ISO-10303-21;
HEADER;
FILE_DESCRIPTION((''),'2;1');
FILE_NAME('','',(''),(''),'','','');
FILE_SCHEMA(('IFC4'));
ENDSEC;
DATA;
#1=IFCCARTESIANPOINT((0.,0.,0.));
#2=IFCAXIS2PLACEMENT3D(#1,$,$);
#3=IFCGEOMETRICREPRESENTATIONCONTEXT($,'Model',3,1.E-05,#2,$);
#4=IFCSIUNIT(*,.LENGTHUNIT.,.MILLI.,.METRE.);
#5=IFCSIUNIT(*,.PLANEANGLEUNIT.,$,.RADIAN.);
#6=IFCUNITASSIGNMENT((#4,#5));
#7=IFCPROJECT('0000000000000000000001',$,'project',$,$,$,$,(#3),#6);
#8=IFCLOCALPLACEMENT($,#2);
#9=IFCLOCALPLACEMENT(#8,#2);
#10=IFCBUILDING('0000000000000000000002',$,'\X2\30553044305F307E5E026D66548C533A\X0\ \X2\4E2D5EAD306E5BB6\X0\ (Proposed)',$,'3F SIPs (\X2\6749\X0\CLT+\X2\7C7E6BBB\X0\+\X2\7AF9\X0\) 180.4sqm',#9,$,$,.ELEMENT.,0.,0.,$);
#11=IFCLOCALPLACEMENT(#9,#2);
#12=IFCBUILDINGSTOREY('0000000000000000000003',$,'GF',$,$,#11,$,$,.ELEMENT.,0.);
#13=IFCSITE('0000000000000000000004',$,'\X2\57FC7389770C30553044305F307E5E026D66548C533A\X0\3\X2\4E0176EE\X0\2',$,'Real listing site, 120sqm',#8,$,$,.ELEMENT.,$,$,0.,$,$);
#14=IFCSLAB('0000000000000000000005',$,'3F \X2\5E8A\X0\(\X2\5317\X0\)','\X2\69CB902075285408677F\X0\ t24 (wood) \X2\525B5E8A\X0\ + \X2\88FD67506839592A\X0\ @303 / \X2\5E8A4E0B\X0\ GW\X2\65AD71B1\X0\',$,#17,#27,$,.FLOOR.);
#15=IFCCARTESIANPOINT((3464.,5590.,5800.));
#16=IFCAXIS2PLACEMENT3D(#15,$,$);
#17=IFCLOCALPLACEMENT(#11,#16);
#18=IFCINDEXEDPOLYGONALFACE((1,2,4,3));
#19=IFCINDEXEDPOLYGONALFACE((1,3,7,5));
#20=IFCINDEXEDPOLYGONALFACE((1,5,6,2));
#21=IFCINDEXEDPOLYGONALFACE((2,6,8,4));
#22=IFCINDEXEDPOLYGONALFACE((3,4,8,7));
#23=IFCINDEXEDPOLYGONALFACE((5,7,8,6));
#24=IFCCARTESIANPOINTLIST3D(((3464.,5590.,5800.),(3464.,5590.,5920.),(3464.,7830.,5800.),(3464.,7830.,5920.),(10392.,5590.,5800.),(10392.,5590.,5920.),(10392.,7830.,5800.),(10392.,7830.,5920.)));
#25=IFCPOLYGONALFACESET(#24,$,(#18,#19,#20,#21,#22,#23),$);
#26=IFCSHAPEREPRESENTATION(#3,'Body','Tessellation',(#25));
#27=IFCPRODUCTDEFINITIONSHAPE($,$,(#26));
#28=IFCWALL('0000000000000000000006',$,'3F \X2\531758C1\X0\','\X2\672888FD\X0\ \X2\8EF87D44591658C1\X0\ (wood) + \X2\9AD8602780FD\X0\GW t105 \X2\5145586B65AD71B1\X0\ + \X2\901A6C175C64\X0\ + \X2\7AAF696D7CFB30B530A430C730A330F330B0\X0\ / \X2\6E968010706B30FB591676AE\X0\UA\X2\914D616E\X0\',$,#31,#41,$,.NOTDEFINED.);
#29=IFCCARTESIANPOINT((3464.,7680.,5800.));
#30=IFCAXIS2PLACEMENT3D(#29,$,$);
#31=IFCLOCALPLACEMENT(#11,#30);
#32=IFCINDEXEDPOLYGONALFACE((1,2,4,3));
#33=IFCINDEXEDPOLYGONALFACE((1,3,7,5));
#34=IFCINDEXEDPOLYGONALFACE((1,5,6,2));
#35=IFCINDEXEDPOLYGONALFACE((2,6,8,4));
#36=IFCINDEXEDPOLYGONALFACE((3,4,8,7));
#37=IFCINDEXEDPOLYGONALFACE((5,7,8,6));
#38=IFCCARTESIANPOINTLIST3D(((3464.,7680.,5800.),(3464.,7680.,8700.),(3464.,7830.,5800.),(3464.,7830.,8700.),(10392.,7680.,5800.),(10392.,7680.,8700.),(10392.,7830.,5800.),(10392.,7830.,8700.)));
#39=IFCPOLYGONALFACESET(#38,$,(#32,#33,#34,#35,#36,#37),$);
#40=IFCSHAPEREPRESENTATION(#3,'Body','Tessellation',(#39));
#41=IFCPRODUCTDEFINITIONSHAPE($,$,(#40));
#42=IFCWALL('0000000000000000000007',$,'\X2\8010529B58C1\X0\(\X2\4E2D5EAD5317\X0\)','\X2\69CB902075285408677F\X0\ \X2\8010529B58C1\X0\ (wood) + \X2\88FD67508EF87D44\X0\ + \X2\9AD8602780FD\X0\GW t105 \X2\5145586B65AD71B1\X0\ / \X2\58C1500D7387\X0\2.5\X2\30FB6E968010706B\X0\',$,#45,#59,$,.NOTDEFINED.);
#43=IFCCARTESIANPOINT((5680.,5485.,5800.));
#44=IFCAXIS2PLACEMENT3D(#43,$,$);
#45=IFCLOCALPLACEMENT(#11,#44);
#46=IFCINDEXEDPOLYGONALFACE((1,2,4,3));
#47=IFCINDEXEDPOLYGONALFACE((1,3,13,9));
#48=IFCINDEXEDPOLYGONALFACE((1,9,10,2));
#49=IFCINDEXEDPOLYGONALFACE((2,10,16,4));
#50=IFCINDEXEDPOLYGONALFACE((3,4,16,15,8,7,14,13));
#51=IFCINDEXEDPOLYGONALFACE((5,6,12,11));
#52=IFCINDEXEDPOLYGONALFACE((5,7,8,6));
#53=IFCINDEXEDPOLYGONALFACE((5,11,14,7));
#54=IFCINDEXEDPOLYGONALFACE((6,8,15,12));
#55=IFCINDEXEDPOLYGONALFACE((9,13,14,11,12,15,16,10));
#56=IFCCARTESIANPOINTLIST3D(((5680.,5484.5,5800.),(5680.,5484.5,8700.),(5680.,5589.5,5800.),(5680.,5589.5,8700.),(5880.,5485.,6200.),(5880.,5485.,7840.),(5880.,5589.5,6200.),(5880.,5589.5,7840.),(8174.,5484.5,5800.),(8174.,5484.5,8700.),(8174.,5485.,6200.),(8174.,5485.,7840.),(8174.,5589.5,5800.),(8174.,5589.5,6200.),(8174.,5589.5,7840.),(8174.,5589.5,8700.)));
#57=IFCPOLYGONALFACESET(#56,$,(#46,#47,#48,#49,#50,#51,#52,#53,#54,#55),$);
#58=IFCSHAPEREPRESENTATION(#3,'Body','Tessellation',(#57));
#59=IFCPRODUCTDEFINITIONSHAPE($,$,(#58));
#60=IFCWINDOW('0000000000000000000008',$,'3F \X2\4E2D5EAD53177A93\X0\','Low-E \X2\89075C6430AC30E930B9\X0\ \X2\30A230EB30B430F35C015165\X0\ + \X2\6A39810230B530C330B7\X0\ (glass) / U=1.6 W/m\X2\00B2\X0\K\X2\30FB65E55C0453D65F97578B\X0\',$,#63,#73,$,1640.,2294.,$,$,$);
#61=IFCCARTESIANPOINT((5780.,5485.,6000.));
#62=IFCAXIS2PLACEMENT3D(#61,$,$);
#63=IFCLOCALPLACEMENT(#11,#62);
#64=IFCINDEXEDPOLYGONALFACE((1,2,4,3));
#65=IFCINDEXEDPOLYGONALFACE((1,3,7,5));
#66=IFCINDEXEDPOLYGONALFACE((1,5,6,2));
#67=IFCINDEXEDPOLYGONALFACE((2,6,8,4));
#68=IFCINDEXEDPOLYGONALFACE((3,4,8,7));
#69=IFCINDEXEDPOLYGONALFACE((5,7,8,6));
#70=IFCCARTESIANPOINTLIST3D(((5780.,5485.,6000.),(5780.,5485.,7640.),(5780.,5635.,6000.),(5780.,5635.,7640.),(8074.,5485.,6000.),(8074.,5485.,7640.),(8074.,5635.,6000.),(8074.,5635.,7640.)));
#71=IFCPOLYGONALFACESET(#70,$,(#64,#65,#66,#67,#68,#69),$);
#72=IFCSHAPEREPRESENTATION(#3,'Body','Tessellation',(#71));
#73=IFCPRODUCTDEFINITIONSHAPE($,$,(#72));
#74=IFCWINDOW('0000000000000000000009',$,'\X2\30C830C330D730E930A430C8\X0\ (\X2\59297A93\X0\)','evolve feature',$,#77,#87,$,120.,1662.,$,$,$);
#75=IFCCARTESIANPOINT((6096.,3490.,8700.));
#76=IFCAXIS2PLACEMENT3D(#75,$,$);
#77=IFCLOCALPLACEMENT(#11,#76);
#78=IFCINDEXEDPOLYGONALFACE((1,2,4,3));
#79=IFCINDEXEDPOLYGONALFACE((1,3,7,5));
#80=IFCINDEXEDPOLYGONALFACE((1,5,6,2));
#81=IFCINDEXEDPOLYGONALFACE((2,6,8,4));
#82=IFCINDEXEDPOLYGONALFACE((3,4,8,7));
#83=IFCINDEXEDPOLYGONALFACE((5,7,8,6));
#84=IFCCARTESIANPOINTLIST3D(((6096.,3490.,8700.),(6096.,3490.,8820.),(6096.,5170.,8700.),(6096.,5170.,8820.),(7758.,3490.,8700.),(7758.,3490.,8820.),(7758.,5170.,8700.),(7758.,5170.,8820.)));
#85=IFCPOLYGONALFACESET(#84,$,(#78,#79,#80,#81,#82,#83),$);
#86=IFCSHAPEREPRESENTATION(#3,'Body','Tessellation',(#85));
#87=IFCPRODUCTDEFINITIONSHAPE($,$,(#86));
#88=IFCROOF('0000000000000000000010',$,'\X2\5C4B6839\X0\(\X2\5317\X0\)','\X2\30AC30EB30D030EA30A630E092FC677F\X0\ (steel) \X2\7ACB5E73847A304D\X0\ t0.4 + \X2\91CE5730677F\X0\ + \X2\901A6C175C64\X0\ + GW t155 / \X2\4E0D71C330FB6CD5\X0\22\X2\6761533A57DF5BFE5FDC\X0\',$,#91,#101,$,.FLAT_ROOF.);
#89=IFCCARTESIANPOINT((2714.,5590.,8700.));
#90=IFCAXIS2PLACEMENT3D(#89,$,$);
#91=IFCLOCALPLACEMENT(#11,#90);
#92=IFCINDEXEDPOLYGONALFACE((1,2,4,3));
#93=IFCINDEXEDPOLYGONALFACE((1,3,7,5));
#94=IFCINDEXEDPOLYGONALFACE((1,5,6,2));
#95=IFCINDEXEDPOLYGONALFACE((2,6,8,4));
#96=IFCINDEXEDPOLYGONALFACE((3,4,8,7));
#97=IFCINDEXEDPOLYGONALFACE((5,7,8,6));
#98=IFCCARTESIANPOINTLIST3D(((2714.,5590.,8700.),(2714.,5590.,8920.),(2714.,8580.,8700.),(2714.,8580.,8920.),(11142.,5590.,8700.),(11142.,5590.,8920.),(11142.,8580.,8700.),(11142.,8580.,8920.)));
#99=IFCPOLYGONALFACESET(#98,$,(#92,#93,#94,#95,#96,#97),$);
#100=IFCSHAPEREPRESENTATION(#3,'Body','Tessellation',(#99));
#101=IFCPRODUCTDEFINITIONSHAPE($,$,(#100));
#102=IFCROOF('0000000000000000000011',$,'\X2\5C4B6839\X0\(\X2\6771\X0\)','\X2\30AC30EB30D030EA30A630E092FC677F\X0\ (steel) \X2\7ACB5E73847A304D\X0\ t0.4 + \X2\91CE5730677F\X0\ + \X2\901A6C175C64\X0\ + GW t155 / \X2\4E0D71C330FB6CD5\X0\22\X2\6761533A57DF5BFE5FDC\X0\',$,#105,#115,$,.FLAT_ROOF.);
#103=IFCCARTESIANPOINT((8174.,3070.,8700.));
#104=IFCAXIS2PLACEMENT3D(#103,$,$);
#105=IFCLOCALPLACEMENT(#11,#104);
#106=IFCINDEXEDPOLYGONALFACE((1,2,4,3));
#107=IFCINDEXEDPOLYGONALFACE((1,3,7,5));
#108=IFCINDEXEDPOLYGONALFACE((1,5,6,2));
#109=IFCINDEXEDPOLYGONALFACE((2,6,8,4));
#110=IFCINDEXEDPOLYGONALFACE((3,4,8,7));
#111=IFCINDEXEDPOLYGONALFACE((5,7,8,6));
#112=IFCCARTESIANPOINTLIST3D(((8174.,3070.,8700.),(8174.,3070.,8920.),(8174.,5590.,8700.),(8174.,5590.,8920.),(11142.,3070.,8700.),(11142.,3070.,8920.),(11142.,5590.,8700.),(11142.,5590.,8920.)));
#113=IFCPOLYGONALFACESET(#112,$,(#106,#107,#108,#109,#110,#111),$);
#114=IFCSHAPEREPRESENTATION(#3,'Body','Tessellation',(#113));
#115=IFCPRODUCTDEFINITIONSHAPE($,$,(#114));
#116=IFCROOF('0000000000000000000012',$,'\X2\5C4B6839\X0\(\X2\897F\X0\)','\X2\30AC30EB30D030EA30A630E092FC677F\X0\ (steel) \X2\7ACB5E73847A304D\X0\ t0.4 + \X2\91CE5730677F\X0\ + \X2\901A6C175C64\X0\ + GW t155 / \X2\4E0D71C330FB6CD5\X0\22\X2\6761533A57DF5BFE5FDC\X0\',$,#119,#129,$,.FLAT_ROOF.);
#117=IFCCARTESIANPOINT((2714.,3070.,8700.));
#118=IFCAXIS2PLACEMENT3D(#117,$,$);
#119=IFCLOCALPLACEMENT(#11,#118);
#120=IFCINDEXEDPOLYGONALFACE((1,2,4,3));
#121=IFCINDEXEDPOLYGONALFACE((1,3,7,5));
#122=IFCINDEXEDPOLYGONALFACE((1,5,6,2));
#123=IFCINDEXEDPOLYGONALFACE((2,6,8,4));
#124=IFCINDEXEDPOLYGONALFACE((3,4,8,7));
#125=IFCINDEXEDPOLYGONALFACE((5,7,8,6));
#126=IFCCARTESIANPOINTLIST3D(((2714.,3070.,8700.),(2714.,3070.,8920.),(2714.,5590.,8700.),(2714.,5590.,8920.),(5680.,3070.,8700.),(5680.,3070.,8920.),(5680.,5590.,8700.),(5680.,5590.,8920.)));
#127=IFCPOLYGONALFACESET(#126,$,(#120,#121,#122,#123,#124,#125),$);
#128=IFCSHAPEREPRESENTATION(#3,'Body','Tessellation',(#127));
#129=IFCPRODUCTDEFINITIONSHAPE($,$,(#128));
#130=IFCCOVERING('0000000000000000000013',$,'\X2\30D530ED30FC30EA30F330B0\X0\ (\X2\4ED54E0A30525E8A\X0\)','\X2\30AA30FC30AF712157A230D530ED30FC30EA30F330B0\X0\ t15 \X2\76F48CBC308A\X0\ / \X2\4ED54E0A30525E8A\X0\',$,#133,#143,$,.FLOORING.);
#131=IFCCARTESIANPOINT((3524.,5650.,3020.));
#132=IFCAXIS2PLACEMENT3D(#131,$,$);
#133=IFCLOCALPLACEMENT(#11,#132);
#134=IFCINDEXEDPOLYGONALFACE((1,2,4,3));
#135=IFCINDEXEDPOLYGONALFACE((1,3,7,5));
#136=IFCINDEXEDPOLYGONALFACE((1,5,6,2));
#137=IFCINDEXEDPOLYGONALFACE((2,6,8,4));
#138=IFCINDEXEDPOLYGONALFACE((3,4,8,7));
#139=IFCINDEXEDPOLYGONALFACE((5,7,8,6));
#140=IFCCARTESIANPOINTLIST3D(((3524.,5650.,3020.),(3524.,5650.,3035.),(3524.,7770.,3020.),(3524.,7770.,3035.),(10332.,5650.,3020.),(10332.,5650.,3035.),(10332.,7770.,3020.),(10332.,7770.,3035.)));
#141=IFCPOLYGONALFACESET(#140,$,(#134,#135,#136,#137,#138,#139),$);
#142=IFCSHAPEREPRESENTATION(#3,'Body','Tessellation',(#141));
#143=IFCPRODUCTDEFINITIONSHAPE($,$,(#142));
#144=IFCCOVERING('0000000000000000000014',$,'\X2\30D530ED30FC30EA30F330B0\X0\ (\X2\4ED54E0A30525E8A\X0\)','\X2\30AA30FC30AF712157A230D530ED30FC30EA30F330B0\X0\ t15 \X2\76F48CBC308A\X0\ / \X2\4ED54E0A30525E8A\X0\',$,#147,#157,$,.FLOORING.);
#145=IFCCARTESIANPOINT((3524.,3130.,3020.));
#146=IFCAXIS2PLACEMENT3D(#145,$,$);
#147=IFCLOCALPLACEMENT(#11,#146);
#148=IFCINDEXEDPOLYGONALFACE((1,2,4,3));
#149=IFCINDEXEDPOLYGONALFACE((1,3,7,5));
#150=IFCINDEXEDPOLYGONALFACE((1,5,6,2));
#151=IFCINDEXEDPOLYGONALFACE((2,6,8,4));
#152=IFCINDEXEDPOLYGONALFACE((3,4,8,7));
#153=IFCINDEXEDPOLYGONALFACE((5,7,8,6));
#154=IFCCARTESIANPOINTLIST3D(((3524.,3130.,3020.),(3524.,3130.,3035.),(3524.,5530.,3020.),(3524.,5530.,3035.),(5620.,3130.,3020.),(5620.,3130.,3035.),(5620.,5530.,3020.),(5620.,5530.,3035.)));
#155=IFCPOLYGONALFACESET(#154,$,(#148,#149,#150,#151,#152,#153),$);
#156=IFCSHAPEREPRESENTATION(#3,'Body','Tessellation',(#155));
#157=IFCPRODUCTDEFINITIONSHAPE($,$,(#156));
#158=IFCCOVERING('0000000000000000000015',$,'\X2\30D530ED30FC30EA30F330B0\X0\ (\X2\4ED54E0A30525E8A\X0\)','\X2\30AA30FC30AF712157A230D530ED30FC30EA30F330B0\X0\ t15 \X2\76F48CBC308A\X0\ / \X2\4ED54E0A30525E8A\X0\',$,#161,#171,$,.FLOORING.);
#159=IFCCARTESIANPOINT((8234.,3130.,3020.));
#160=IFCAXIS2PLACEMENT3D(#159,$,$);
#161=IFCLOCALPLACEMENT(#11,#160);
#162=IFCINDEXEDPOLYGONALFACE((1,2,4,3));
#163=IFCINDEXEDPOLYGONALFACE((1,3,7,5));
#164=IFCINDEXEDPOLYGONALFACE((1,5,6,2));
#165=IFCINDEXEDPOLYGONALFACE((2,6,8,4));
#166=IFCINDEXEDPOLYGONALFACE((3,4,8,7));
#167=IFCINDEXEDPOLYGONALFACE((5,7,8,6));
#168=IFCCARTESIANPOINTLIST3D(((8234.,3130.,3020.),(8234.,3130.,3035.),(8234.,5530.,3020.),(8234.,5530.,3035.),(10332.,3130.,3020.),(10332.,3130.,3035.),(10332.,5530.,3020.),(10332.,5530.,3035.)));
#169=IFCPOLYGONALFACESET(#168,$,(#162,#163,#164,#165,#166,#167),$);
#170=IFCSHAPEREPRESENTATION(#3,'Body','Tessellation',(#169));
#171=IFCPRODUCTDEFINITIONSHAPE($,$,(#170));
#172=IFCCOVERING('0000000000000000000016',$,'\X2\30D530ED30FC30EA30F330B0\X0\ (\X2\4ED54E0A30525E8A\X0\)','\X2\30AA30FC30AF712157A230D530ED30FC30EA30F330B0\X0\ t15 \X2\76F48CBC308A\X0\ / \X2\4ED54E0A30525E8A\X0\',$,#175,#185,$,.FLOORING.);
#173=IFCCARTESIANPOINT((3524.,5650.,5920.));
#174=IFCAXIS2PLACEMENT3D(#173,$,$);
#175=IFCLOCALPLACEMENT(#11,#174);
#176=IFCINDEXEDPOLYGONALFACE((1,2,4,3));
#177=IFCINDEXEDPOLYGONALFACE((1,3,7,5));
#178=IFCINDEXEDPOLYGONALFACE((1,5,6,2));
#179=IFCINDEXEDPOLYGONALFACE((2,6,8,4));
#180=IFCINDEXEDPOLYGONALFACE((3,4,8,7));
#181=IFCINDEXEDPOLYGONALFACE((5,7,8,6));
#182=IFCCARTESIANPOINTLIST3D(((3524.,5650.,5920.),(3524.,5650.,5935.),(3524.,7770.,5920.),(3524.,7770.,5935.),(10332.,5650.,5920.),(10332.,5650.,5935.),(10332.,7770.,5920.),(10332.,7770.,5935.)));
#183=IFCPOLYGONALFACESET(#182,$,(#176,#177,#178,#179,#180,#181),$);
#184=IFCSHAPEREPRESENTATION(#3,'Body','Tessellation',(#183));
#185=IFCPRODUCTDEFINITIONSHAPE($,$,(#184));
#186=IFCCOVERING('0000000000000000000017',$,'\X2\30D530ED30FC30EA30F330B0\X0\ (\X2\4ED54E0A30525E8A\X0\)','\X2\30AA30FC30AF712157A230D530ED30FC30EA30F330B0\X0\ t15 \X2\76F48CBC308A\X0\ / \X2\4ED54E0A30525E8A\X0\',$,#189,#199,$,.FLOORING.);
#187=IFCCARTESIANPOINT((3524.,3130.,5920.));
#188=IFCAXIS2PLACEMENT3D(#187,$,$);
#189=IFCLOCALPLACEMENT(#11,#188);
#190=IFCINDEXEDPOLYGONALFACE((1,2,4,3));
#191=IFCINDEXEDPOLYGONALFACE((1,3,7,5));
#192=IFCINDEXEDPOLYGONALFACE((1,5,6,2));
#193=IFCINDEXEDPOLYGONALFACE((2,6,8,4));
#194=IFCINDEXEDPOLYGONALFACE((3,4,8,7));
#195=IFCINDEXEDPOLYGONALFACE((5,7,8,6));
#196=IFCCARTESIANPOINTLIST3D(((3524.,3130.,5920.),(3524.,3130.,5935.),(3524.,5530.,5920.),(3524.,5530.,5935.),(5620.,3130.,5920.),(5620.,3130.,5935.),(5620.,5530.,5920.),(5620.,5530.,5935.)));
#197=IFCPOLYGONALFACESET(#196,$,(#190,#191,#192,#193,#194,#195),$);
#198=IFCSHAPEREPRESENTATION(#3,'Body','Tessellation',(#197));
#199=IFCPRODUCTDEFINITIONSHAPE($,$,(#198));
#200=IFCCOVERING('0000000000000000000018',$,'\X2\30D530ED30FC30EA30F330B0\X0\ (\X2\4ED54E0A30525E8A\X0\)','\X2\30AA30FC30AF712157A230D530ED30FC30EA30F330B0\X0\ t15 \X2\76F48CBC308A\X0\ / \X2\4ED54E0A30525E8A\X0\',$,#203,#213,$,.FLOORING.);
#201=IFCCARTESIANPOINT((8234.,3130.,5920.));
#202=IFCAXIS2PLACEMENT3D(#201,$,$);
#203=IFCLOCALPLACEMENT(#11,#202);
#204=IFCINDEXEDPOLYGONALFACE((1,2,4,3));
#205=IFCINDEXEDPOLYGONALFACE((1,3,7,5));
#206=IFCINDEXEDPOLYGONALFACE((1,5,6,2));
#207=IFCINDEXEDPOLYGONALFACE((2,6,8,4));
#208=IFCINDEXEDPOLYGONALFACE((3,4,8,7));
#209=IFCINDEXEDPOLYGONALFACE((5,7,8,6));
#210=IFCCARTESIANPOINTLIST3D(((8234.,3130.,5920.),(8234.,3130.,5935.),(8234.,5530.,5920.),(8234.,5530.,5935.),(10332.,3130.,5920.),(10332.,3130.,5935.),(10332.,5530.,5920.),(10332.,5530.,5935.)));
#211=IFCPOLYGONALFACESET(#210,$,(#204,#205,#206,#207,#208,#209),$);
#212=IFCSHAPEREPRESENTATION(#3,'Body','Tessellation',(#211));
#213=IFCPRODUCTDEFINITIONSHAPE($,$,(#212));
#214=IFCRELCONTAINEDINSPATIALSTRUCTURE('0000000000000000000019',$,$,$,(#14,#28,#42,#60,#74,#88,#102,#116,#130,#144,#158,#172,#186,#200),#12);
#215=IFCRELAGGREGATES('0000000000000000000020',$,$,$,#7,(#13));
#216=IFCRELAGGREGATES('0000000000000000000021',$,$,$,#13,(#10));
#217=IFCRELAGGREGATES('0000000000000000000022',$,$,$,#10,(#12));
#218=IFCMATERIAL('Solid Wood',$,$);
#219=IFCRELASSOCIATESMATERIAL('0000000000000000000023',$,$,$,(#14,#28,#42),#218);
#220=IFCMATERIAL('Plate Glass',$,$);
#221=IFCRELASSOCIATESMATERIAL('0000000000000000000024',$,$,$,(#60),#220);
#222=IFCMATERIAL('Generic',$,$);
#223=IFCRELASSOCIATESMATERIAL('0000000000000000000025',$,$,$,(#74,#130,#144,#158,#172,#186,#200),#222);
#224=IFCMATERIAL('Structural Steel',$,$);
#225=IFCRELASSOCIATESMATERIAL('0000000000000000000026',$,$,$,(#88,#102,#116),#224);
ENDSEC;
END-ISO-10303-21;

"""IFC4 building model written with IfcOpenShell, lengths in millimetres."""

from ifc_helpers import new_model, si_unit, frame, frame_2d, origin, place, context, project, spatial, rectangle, extrude, material, element, fill, save


model = new_model("IFC4")

# Units and contexts
model_context = context("Model", 3, precision=1e-05, world=origin())
ifc_project = project(units=[si_unit("LENGTHUNIT", "METRE", prefix="MILLI"), si_unit("PLANEANGLEUNIT", "RADIAN")], contexts=[model_context])

# Site, building, storey
site_placement = place(None, origin())
site = spatial("IfcSite", under=ifc_project, at=site_placement, Name="埼玉県さいたま市浦和区3丁目2", ObjectType="Real listing site, 120sqm", CompositionType="ELEMENT", RefElevation=0.0)
building_placement = place(site_placement, origin())
building = spatial("IfcBuilding", under=site, at=building_placement, Name="さいたま市浦和区 中庭の家 (Proposed)", ObjectType="3F SIPs (杉CLT+籾殻+竹) 180.4sqm", CompositionType="ELEMENT", ElevationOfRefHeight=0.0, ElevationOfTerrain=0.0)
storey_placement = place(building_placement, origin())
storey = spatial("IfcBuildingStorey", under=building, at=storey_placement, Name="GF", CompositionType="ELEMENT", Elevation=0.0)

# Slab
ifc_material_1 = material(Name="Solid Wood")
slab_placement = place(storey_placement, frame((3464.0, 5590.0, 5800.0)))
element("IfcSlab", 1, at=slab_placement, inside=storey, material=ifc_material_1, Name="3F 床(北)", Description="構造用合板 t24 (wood) 剛床 + 製材根太 @303 / 床下 GW断熱", PredefinedType="FLOOR", context=model_context, shape_type="SweptSolid", body=[
    extrude(rectangle(XDim=6928.0, YDim=2240.0, at=frame_2d((3464.0, 1120.0))), frame((3464.0, 5590.0, 5800.0)), (0.0, 0.0, 1.0), 120.0),
])

# Wall
wall_1_placement = place(storey_placement, frame((3464.0, 7680.0, 5800.0)))
element("IfcWall", 2, at=wall_1_placement, inside=storey, material=ifc_material_1, Name="3F 北壁", Description="木製 軸組外壁 (wood) + 高性能GW t105 充填断熱 + 通気層 + 窯業系サイディング / 準耐火・外皮UA配慮", PredefinedType="NOTDEFINED", context=model_context, shape_type="SweptSolid", body=[
    extrude(rectangle(XDim=6928.0, YDim=150.0, at=frame_2d((3464.0, 75.0))), frame((3464.0, 7680.0, 5800.0)), (0.0, 0.0, 1.0), 2900.0),
])

# Wall, opening, window
wall_2_placement = place(storey_placement, frame((5680.0, 5485.0, 5800.0)))
wall_2 = element("IfcWall", 3, at=wall_2_placement, inside=storey, material=ifc_material_1, Name="耐力壁(中庭北)", Description="構造用合板 耐力壁 (wood) + 製材軸組 + 高性能GW t105 充填断熱 / 壁倍率2.5・準耐火", PredefinedType="NOTDEFINED", context=model_context, shape_type="SweptSolid", body=[
    extrude(rectangle(XDim=2494.0, YDim=105.0, at=frame_2d((1247.0, 52.0))), frame((5680.0, 5485.0, 5800.0)), (0.0, 0.0, 1.0), 2900.0),
])
opening_placement = place(storey_placement, frame((5780.0, 5485.0, 6000.0)))
opening = element("IfcOpeningElement", 4, at=opening_placement, cuts=wall_2, PredefinedType="NOTDEFINED", context=model_context, shape_type="SweptSolid", body=[
    extrude(rectangle(XDim=2294.0, YDim=150.0, at=frame_2d((1147.0, 75.0))), frame((5780.0, 5485.0, 6000.0)), (0.0, 0.0, 1.0), 1640.0),
])
ifc_material_2 = material(Name="Plate Glass")
window_1_placement = place(storey_placement, frame((5780.0, 5485.0, 6000.0)))
window_1 = element("IfcWindow", 5, at=window_1_placement, inside=storey, material=ifc_material_2, Name="3F 中庭北窓", Description="Low-E 複層ガラス アルゴン封入 + 樹脂サッシ (glass) / U=1.6 W/m²K・日射取得型", OverallHeight=1640.0, OverallWidth=2294.0, context=model_context, shape_type="SweptSolid", body=[
    extrude(rectangle(XDim=2294.0, YDim=150.0, at=frame_2d((1147.0, 75.0))), frame((5780.0, 5485.0, 6000.0)), (0.0, 0.0, 1.0), 1640.0),
])
fill(opening, window_1)

# Window
ifc_material_3 = material(Name="Generic")
window_2_placement = place(storey_placement, frame((6096.0, 3490.0, 8700.0)))
element("IfcWindow", 6, at=window_2_placement, inside=storey, material=ifc_material_3, Name="トップライト (天窓)", Description="evolve feature", OverallHeight=120.0, OverallWidth=1662.0, context=model_context, shape_type="SweptSolid", body=[
    extrude(rectangle(XDim=1662.0, YDim=1680.0, at=frame_2d((831.0, 840.0))), frame((6096.0, 3490.0, 8700.0)), (0.0, 0.0, 1.0), 120.0),
])

# Roofs
ifc_material_4 = material(Name="Structural Steel")
roof_1_placement = place(storey_placement, frame((2714.0, 5590.0, 8700.0)))
element("IfcRoof", 7, at=roof_1_placement, inside=storey, material=ifc_material_4, Name="屋根(北)", Description="ガルバリウム鋼板 (steel) 立平葺き t0.4 + 野地板 + 通気層 + GW t155 / 不燃・法22条区域対応", PredefinedType="FLAT_ROOF", context=model_context, shape_type="SweptSolid", body=[
    extrude(rectangle(XDim=8428.0, YDim=2990.0, at=frame_2d((4214.0, 1495.0))), frame((2714.0, 5590.0, 8700.0)), (0.0, 0.0, 1.0), 220.0),
])
roof_2_placement = place(storey_placement, frame((8174.0, 3070.0, 8700.0)))
element("IfcRoof", 8, at=roof_2_placement, inside=storey, material=ifc_material_4, Name="屋根(東)", Description="ガルバリウム鋼板 (steel) 立平葺き t0.4 + 野地板 + 通気層 + GW t155 / 不燃・法22条区域対応", PredefinedType="FLAT_ROOF", context=model_context, shape_type="SweptSolid", body=[
    extrude(rectangle(XDim=2968.0, YDim=2520.0, at=frame_2d((1484.0, 1260.0))), frame((8174.0, 3070.0, 8700.0)), (0.0, 0.0, 1.0), 220.0),
])
roof_3_placement = place(storey_placement, frame((2714.0, 3070.0, 8700.0)))
element("IfcRoof", 9, at=roof_3_placement, inside=storey, material=ifc_material_4, Name="屋根(西)", Description="ガルバリウム鋼板 (steel) 立平葺き t0.4 + 野地板 + 通気層 + GW t155 / 不燃・法22条区域対応", PredefinedType="FLAT_ROOF", context=model_context, shape_type="SweptSolid", body=[
    extrude(rectangle(XDim=2966.0, YDim=2520.0, at=frame_2d((1483.0, 1260.0))), frame((2714.0, 3070.0, 8700.0)), (0.0, 0.0, 1.0), 220.0),
])

# Coverings
covering_1_placement = place(storey_placement, frame((3524.0, 5650.0, 3020.0)))
element("IfcCovering", 10, at=covering_1_placement, inside=storey, material=ifc_material_3, Name="フローリング (仕上げ床)", Description="オーク無垢フローリング t15 直貼り / 仕上げ床", PredefinedType="FLOORING", context=model_context, shape_type="SweptSolid", body=[
    extrude(rectangle(XDim=6808.0, YDim=2120.0, at=frame_2d((3404.0, 1060.0))), frame((3524.0, 5650.0, 3020.0)), (0.0, 0.0, 1.0), 15.0),
])
covering_2_placement = place(storey_placement, frame((3524.0, 3130.0, 3020.0)))
element("IfcCovering", 11, at=covering_2_placement, inside=storey, material=ifc_material_3, Name="フローリング (仕上げ床)", Description="オーク無垢フローリング t15 直貼り / 仕上げ床", PredefinedType="FLOORING", context=model_context, shape_type="SweptSolid", body=[
    extrude(rectangle(XDim=2096.0, YDim=2400.0, at=frame_2d((1048.0, 1200.0))), frame((3524.0, 3130.0, 3020.0)), (0.0, 0.0, 1.0), 15.0),
])
covering_3_placement = place(storey_placement, frame((8234.0, 3130.0, 3020.0)))
element("IfcCovering", 12, at=covering_3_placement, inside=storey, material=ifc_material_3, Name="フローリング (仕上げ床)", Description="オーク無垢フローリング t15 直貼り / 仕上げ床", PredefinedType="FLOORING", context=model_context, shape_type="SweptSolid", body=[
    extrude(rectangle(XDim=2098.0, YDim=2400.0, at=frame_2d((1049.0, 1200.0))), frame((8234.0, 3130.0, 3020.0)), (0.0, 0.0, 1.0), 15.0),
])
covering_4_placement = place(storey_placement, frame((3524.0, 5650.0, 5920.0)))
element("IfcCovering", 13, at=covering_4_placement, inside=storey, material=ifc_material_3, Name="フローリング (仕上げ床)", Description="オーク無垢フローリング t15 直貼り / 仕上げ床", PredefinedType="FLOORING", context=model_context, shape_type="SweptSolid", body=[
    extrude(rectangle(XDim=6808.0, YDim=2120.0, at=frame_2d((3404.0, 1060.0))), frame((3524.0, 5650.0, 5920.0)), (0.0, 0.0, 1.0), 15.0),
])
covering_5_placement = place(storey_placement, frame((3524.0, 3130.0, 5920.0)))
element("IfcCovering", 14, at=covering_5_placement, inside=storey, material=ifc_material_3, Name="フローリング (仕上げ床)", Description="オーク無垢フローリング t15 直貼り / 仕上げ床", PredefinedType="FLOORING", context=model_context, shape_type="SweptSolid", body=[
    extrude(rectangle(XDim=2096.0, YDim=2400.0, at=frame_2d((1048.0, 1200.0))), frame((3524.0, 3130.0, 5920.0)), (0.0, 0.0, 1.0), 15.0),
])
covering_6_placement = place(storey_placement, frame((8234.0, 3130.0, 5920.0)))
element("IfcCovering", 15, at=covering_6_placement, inside=storey, material=ifc_material_3, Name="フローリング (仕上げ床)", Description="オーク無垢フローリング t15 直貼り / 仕上げ床", PredefinedType="FLOORING", context=model_context, shape_type="SweptSolid", body=[
    extrude(rectangle(XDim=2098.0, YDim=2400.0, at=frame_2d((1049.0, 1200.0))), frame((8234.0, 3130.0, 5920.0)), (0.0, 0.0, 1.0), 15.0),
])

save(model, "model.ifc")
